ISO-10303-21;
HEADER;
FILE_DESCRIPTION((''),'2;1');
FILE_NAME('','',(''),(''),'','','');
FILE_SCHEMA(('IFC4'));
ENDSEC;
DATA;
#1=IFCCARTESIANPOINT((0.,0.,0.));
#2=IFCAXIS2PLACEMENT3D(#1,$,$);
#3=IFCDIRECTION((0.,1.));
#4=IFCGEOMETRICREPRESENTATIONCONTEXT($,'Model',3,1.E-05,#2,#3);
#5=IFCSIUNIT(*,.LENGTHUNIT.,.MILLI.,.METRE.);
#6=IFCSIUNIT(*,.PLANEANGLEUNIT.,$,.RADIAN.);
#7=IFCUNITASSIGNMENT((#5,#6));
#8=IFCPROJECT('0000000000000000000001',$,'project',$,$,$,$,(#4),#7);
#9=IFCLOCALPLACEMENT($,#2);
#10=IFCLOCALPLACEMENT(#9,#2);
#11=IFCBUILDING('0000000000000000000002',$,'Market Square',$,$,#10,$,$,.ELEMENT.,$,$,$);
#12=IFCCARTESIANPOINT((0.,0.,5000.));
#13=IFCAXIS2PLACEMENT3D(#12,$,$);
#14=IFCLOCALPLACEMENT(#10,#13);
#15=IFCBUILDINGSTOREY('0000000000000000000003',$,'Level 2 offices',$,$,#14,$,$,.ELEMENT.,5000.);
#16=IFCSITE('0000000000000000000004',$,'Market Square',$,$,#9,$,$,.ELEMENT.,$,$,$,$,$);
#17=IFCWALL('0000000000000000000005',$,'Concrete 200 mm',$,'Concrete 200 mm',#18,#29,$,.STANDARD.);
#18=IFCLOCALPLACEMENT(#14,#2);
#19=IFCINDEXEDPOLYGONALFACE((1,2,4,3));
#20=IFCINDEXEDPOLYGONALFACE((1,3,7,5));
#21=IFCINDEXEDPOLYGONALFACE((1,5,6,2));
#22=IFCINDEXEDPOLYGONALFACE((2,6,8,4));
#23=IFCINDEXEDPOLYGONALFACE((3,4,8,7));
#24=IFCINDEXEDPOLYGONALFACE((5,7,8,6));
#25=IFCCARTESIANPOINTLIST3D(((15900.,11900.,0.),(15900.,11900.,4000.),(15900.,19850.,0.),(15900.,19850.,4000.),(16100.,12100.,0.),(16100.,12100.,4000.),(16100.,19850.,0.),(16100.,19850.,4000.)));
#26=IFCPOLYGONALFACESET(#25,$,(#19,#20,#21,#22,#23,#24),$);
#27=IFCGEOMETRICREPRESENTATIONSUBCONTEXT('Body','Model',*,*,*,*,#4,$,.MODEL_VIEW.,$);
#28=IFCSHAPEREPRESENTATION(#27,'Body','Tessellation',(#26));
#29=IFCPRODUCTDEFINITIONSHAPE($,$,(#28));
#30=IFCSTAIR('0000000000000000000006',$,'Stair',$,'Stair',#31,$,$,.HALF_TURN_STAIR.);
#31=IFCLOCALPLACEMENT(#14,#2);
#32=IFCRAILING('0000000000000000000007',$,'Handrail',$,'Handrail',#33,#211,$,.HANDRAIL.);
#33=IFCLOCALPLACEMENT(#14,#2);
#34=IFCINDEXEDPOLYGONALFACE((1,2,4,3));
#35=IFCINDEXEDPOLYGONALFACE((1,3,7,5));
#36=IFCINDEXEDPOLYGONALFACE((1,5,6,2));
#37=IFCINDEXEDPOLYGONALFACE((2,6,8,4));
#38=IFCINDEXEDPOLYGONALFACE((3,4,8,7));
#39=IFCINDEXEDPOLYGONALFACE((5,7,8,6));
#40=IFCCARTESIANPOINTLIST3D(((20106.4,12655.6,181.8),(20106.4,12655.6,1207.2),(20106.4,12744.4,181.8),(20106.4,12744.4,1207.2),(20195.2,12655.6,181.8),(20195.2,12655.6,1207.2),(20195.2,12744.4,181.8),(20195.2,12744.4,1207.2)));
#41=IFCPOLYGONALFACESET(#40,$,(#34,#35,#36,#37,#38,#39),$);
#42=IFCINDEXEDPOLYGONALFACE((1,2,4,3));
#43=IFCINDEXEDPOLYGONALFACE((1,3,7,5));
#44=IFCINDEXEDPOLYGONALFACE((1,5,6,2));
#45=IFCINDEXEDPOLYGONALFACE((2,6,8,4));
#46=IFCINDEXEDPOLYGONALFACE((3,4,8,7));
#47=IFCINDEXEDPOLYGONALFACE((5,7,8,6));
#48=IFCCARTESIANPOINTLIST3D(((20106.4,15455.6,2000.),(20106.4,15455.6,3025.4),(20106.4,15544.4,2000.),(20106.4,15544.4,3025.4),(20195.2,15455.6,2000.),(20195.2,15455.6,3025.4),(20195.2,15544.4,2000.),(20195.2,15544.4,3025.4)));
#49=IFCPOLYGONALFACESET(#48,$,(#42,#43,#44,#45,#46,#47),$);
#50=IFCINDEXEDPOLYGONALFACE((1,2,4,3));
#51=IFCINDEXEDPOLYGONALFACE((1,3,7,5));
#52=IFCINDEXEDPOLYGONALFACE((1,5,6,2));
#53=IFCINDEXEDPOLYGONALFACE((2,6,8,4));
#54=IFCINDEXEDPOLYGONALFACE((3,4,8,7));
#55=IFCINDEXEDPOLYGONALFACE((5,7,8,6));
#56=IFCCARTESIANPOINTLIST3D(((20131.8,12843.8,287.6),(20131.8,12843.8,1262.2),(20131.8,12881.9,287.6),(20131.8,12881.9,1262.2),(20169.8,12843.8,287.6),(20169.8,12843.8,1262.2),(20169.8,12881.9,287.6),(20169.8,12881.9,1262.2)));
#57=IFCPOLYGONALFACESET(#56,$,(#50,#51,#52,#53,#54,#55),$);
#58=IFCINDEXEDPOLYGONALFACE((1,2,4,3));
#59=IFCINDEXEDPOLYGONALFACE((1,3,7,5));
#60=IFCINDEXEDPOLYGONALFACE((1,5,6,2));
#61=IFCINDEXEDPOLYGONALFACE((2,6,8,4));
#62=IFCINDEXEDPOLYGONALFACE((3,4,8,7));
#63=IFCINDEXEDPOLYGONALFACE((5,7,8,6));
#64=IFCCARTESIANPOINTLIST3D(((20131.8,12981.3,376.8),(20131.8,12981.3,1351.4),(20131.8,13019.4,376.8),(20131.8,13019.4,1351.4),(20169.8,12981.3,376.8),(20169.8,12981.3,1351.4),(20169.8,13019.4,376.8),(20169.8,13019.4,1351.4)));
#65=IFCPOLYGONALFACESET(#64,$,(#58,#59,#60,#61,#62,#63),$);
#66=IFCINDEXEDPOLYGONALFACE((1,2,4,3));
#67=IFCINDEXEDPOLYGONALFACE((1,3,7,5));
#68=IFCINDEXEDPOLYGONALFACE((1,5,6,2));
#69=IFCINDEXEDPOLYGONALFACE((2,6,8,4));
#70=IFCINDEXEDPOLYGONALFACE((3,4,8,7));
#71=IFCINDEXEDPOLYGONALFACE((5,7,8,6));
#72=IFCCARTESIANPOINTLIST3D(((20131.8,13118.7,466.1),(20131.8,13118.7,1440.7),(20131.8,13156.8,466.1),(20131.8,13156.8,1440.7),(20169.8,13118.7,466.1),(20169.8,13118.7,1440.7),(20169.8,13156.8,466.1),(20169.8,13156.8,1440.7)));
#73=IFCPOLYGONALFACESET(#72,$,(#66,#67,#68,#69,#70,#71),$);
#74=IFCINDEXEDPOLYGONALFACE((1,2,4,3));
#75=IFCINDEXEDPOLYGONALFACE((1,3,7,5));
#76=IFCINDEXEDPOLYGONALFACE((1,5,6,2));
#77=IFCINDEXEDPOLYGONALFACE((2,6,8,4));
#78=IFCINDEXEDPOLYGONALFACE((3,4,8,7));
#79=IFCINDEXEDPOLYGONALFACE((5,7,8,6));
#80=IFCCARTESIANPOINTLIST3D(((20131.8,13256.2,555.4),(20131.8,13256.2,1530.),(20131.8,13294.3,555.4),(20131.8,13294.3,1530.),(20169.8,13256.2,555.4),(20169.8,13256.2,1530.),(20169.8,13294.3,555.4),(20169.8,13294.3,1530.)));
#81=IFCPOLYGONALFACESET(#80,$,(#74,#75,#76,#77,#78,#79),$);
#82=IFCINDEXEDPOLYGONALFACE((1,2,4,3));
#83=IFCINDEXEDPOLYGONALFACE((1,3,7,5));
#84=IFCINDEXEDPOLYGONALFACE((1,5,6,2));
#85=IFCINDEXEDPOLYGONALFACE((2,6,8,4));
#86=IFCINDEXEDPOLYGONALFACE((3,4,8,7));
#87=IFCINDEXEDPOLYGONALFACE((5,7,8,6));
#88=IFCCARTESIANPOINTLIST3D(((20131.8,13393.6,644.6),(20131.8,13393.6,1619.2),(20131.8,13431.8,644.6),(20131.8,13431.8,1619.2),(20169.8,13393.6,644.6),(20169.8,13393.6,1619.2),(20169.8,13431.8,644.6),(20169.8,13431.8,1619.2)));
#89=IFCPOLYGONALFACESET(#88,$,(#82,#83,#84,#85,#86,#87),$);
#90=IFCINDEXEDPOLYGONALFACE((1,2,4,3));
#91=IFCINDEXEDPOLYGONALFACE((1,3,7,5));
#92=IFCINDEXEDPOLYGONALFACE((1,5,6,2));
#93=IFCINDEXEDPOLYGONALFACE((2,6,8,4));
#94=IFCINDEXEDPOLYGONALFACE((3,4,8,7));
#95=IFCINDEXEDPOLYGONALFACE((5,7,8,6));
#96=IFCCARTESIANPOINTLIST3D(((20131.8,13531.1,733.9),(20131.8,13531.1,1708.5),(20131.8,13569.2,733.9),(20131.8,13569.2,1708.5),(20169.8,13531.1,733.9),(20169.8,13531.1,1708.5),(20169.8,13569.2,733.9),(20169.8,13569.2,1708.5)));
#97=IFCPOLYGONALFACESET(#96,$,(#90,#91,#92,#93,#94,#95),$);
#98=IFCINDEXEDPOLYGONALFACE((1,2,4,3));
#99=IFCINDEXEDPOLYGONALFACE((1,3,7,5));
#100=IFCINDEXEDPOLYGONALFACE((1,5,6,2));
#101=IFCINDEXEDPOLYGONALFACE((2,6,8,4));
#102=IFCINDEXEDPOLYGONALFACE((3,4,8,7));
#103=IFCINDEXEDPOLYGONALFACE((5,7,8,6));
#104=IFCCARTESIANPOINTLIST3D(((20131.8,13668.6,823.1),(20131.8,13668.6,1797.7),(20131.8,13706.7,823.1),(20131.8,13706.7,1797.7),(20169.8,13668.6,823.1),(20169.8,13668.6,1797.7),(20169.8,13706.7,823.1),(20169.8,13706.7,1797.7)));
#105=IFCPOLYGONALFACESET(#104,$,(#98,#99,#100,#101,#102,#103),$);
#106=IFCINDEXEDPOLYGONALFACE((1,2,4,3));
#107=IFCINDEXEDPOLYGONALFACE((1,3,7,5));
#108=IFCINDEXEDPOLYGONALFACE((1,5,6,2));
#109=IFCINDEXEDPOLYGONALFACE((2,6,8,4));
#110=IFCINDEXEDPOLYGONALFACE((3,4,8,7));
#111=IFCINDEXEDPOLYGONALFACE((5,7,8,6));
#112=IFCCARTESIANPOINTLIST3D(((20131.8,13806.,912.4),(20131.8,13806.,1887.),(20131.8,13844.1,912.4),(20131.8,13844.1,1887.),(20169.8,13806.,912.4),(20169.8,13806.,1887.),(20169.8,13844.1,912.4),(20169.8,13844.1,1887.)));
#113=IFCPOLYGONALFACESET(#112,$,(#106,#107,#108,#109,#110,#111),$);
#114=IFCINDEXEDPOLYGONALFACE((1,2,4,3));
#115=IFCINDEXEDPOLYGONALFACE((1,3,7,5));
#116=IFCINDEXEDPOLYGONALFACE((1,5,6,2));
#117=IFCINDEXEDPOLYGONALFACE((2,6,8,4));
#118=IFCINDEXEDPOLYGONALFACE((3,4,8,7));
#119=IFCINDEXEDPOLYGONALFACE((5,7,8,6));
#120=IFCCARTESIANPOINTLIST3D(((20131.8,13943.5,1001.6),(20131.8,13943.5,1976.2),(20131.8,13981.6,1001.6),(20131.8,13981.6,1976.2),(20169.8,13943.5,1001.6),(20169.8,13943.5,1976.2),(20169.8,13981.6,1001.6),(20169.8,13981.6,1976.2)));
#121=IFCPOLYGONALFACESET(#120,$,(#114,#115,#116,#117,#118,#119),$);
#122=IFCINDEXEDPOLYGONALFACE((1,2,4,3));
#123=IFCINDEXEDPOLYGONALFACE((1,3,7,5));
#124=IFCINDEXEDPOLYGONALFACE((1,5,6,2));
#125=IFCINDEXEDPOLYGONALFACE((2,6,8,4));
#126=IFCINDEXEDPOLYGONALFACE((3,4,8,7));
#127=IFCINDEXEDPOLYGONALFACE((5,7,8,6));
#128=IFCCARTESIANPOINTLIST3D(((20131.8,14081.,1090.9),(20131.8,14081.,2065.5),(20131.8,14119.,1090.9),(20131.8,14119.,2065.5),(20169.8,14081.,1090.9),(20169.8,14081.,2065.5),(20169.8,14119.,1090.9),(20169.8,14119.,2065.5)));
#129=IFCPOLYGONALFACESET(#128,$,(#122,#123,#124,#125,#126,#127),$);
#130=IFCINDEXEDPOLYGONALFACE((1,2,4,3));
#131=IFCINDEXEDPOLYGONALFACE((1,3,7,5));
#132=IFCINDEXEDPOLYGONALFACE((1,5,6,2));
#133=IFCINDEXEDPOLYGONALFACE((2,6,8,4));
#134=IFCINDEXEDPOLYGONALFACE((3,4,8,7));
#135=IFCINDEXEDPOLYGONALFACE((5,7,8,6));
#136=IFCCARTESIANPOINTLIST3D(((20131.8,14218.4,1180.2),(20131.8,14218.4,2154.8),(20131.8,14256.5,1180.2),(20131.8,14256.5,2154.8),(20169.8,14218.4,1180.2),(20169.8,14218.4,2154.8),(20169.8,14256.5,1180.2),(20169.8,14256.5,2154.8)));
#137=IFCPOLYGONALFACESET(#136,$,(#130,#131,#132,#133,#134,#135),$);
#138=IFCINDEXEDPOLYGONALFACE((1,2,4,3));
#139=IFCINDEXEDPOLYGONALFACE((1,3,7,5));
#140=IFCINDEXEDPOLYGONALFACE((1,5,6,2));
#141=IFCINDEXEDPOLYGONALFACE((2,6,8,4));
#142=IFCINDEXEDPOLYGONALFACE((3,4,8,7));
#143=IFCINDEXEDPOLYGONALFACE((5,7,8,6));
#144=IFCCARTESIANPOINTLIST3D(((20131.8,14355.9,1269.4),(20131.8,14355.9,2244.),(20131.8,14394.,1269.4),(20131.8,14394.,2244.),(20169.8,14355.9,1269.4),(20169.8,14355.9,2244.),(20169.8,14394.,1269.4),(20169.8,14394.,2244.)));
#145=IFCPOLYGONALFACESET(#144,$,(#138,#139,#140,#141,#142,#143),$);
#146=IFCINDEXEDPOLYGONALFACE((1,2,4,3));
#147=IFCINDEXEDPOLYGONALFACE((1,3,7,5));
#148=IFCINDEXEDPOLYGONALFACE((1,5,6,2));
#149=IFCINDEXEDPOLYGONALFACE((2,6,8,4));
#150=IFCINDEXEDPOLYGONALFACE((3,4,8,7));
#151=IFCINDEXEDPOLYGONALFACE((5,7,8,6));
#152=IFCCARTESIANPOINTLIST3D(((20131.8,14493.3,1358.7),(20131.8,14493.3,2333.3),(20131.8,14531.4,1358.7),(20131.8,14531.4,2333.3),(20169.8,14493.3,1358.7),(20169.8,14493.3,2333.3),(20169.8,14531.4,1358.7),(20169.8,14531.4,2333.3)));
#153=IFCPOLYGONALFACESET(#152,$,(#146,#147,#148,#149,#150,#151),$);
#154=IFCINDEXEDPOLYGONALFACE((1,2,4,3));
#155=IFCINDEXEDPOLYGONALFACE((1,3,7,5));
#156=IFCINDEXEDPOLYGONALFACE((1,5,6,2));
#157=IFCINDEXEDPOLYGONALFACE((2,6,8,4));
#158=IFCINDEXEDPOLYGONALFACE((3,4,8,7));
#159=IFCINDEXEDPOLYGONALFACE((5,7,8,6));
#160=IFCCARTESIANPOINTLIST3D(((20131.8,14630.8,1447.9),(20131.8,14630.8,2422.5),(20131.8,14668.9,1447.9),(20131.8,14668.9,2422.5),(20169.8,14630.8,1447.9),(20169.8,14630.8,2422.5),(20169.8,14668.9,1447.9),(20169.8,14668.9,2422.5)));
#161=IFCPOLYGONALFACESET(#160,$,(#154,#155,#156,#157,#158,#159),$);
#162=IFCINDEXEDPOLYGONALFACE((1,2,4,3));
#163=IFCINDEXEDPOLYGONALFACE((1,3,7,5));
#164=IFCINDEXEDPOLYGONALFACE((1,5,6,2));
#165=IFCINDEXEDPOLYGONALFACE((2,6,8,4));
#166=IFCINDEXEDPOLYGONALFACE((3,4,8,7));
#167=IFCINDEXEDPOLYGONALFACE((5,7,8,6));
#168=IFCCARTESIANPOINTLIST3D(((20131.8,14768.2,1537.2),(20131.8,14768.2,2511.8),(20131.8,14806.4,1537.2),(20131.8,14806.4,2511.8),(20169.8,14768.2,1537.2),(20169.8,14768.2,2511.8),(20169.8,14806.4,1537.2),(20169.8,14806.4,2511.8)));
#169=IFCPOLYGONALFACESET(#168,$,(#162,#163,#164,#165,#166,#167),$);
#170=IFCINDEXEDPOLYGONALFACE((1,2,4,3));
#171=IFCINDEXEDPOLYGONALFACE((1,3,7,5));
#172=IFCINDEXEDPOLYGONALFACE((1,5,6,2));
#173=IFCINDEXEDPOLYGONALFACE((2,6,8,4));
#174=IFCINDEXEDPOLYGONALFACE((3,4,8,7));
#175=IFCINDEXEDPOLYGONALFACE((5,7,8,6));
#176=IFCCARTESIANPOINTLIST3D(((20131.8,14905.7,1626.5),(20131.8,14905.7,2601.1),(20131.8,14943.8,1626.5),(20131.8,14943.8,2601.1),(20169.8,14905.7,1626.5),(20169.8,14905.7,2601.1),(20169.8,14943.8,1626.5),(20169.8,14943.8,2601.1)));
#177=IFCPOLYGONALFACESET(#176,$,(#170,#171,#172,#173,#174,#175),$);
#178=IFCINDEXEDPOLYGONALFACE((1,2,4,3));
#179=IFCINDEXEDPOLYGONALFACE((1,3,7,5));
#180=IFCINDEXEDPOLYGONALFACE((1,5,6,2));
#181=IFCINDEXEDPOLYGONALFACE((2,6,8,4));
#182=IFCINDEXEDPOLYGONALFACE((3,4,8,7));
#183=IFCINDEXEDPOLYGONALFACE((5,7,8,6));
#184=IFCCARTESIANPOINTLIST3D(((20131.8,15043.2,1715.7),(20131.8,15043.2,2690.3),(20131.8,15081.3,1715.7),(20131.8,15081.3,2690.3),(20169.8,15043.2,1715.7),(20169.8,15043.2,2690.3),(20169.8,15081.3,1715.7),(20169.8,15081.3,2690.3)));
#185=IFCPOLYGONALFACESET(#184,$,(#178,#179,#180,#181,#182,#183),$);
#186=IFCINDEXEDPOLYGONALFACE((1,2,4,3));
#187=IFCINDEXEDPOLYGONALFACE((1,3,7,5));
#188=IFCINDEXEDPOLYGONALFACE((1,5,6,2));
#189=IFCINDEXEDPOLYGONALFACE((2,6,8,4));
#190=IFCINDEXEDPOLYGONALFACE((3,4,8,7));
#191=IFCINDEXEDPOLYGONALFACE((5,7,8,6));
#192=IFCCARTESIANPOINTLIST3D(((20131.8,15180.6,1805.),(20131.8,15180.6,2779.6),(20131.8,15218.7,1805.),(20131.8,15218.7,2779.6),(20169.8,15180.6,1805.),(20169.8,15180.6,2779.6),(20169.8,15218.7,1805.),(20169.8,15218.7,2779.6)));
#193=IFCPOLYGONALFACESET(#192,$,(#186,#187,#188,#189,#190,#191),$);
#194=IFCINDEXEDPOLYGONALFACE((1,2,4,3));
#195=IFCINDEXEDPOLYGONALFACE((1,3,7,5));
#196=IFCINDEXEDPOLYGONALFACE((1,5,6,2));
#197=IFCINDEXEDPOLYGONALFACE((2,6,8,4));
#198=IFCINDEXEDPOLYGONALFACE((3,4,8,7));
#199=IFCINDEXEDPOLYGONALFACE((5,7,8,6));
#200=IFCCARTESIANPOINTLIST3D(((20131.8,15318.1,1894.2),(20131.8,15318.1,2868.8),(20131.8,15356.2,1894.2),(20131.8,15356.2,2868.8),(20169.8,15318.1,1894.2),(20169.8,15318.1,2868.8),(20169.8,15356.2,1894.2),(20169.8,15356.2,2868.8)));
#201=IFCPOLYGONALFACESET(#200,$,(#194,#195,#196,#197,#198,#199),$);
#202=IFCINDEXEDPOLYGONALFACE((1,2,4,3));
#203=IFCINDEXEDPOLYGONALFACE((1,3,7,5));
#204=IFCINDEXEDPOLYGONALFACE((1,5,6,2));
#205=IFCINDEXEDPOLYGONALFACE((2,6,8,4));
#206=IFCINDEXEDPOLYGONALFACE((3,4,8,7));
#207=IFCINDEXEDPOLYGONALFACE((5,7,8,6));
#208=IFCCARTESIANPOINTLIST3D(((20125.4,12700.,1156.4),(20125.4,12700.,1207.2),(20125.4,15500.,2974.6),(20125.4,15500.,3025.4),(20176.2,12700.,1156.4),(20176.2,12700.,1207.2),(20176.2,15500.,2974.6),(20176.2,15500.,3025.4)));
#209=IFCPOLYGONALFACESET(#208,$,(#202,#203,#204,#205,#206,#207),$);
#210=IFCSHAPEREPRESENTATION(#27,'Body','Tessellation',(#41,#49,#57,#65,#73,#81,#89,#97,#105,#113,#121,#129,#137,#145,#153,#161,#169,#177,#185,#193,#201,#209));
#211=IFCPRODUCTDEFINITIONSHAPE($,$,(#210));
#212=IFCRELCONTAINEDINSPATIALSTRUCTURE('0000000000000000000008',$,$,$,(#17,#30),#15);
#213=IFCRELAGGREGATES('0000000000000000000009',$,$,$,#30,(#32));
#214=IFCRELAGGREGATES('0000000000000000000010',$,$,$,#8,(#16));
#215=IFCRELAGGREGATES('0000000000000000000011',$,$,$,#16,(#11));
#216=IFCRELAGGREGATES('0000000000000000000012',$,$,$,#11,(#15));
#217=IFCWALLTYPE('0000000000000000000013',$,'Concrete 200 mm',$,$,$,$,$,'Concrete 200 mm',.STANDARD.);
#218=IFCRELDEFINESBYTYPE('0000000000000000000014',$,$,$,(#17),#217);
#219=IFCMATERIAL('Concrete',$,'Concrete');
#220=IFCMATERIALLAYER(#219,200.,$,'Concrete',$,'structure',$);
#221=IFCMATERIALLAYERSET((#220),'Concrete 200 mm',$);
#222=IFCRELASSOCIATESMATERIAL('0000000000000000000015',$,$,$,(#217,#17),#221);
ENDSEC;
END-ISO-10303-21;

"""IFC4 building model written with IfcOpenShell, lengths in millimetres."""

from ifc_helpers import new_model, si_unit, direction, frame, origin, origin_with_axes, place, context, subcontext, project, spatial, polyline, outline, extrude, material, layer, layer_set, layer_usage, type_object, element, aggregate, save


model = new_model("IFC4")

# Units and contexts
model_context = context("Model", 3, precision=1e-05, world=origin(), true_north=direction((0.0, 1.0)))
body_context = subcontext(model_context, "Body", "Model", "MODEL_VIEW")
ifc_project = project(units=[si_unit("LENGTHUNIT", "METRE", prefix="MILLI"), si_unit("PLANEANGLEUNIT", "RADIAN")], contexts=[model_context])

# Site, building, storey
site_placement = place(None, origin())
site = spatial("IfcSite", under=ifc_project, at=site_placement, Name="Market Square", CompositionType="ELEMENT")
building_placement = place(site_placement, origin())
building = spatial("IfcBuilding", under=site, at=building_placement, Name="Market Square", CompositionType="ELEMENT")
storey_placement = place(building_placement, frame((0.0, 0.0, 5000.0)))
storey = spatial("IfcBuildingStorey", under=building, at=storey_placement, Name="Level 2 offices", CompositionType="ELEMENT", Elevation=5000.0)

# Wall
ifc_material = material(Name="Concrete", Category="Concrete")
ifc_layer = layer(ifc_material, 200.0, Name="Concrete", Category="structure")
ifc_layer_set = layer_set([ifc_layer], Name="Concrete 200 mm")
ifc_layer_usage = layer_usage(ifc_layer_set, "AXIS2", "NEGATIVE", 100.0)
wall_type = type_object("IfcWallType", Name="Concrete 200 mm", ElementType="Concrete 200 mm", PredefinedType="STANDARD", material=ifc_layer_set)
wall_placement = place(storey_placement, frame((16000.0, 12000.0, 0.0), z_axis=(0.0, 0.0, 1.0), x_axis=(0.0, 1.0, 0.0)))
element("IfcWall", 1, at=wall_placement, inside=storey, type_object=wall_type, material=ifc_layer_usage, Name="Concrete 200 mm", ObjectType="Concrete 200 mm", PredefinedType="STANDARD", context=body_context, shape_type="SweptSolid", body=[
    extrude(outline(polyline([(100.0, -100.0), (7850.0, -100.0), (7850.0, 100.0), (-100.0, 100.0), (100.0, -100.0)])), origin(), (0.0, 0.0, 1.0), 4000.0),
])

# Stair, railing
stair_placement = place(storey_placement, origin_with_axes())
stair = element("IfcStair", 2, at=stair_placement, inside=storey, Name="Stair", ObjectType="Stair", PredefinedType="HALF_TURN_STAIR")
railing_1_placement = place(storey_placement, origin_with_axes())
railing_1 = element("IfcRailing", 3, at=railing_1_placement, Name="Handrail", ObjectType="Handrail", PredefinedType="HANDRAIL", context=body_context, shape_type="SweptSolid", body=[
    extrude(outline(polyline([(-44.5, -44.5), (44.5, -44.5), (44.5, 44.5), (-44.5, 44.5), (-44.5, -44.5)])), frame((20150.8, 12700.0, 181.8), z_axis=(0.0, 0.0, 1.0), x_axis=(1.0, 0.0, 0.0)), (0.0, 0.0, 1.0), 1025.4),
    extrude(outline(polyline([(-44.5, -44.5), (44.5, -44.5), (44.5, 44.5), (-44.5, 44.5), (-44.5, -44.5)])), frame((20150.8, 15500.0, 2000.0), z_axis=(0.0, 0.0, 1.0), x_axis=(1.0, 0.0, 0.0)), (0.0, 0.0, 1.0), 1025.4),
    extrude(outline(polyline([(-19.1, -19.1), (19.1, -19.1), (19.1, 19.1), (-19.1, 19.1), (-19.1, -19.1)])), frame((20150.8, 12862.9, 287.6), z_axis=(0.0, 0.0, 1.0), x_axis=(1.0, 0.0, 0.0)), (0.0, 0.0, 1.0), 974.6),
    extrude(outline(polyline([(-19.1, -19.1), (19.1, -19.1), (19.1, 19.1), (-19.1, 19.1), (-19.1, -19.1)])), frame((20150.8, 13000.3, 376.8), z_axis=(0.0, 0.0, 1.0), x_axis=(1.0, 0.0, 0.0)), (0.0, 0.0, 1.0), 974.6),
    extrude(outline(polyline([(-19.1, -19.1), (19.1, -19.1), (19.1, 19.1), (-19.1, 19.1), (-19.1, -19.1)])), frame((20150.8, 13137.8, 466.1), z_axis=(0.0, 0.0, 1.0), x_axis=(1.0, 0.0, 0.0)), (0.0, 0.0, 1.0), 974.6),
    extrude(outline(polyline([(-19.1, -19.1), (19.1, -19.1), (19.1, 19.1), (-19.1, 19.1), (-19.1, -19.1)])), frame((20150.8, 13275.2, 555.4), z_axis=(0.0, 0.0, 1.0), x_axis=(1.0, 0.0, 0.0)), (0.0, 0.0, 1.0), 974.6),
    extrude(outline(polyline([(-19.1, -19.1), (19.1, -19.1), (19.1, 19.1), (-19.1, 19.1), (-19.1, -19.1)])), frame((20150.8, 13412.7, 644.6), z_axis=(0.0, 0.0, 1.0), x_axis=(1.0, 0.0, 0.0)), (0.0, 0.0, 1.0), 974.6),
    extrude(outline(polyline([(-19.1, -19.1), (19.1, -19.1), (19.1, 19.1), (-19.1, 19.1), (-19.1, -19.1)])), frame((20150.8, 13550.2, 733.9), z_axis=(0.0, 0.0, 1.0), x_axis=(1.0, 0.0, 0.0)), (0.0, 0.0, 1.0), 974.6),
    extrude(outline(polyline([(-19.1, -19.1), (19.1, -19.1), (19.1, 19.1), (-19.1, 19.1), (-19.1, -19.1)])), frame((20150.8, 13687.6, 823.1), z_axis=(0.0, 0.0, 1.0), x_axis=(1.0, 0.0, 0.0)), (0.0, 0.0, 1.0), 974.6),
    extrude(outline(polyline([(-19.1, -19.1), (19.1, -19.1), (19.1, 19.1), (-19.1, 19.1), (-19.1, -19.1)])), frame((20150.8, 13825.1, 912.4), z_axis=(0.0, 0.0, 1.0), x_axis=(1.0, 0.0, 0.0)), (0.0, 0.0, 1.0), 974.6),
    extrude(outline(polyline([(-19.1, -19.1), (19.1, -19.1), (19.1, 19.1), (-19.1, 19.1), (-19.1, -19.1)])), frame((20150.8, 13962.5, 1001.6), z_axis=(0.0, 0.0, 1.0), x_axis=(1.0, 0.0, 0.0)), (0.0, 0.0, 1.0), 974.6),
    extrude(outline(polyline([(-19.1, -19.1), (19.1, -19.1), (19.1, 19.1), (-19.1, 19.1), (-19.1, -19.1)])), frame((20150.8, 14100.0, 1090.9), z_axis=(0.0, 0.0, 1.0), x_axis=(1.0, 0.0, 0.0)), (0.0, 0.0, 1.0), 974.6),
    extrude(outline(polyline([(-19.1, -19.1), (19.1, -19.1), (19.1, 19.1), (-19.1, 19.1), (-19.1, -19.1)])), frame((20150.8, 14237.5, 1180.2), z_axis=(0.0, 0.0, 1.0), x_axis=(1.0, 0.0, 0.0)), (0.0, 0.0, 1.0), 974.6),
    extrude(outline(polyline([(-19.1, -19.1), (19.1, -19.1), (19.1, 19.1), (-19.1, 19.1), (-19.1, -19.1)])), frame((20150.8, 14374.9, 1269.4), z_axis=(0.0, 0.0, 1.0), x_axis=(1.0, 0.0, 0.0)), (0.0, 0.0, 1.0), 974.6),
    extrude(outline(polyline([(-19.1, -19.1), (19.1, -19.1), (19.1, 19.1), (-19.1, 19.1), (-19.1, -19.1)])), frame((20150.8, 14512.4, 1358.7), z_axis=(0.0, 0.0, 1.0), x_axis=(1.0, 0.0, 0.0)), (0.0, 0.0, 1.0), 974.6),
    extrude(outline(polyline([(-19.1, -19.1), (19.1, -19.1), (19.1, 19.1), (-19.1, 19.1), (-19.1, -19.1)])), frame((20150.8, 14649.8, 1447.9), z_axis=(0.0, 0.0, 1.0), x_axis=(1.0, 0.0, 0.0)), (0.0, 0.0, 1.0), 974.6),
    extrude(outline(polyline([(-19.1, -19.1), (19.1, -19.1), (19.1, 19.1), (-19.1, 19.1), (-19.1, -19.1)])), frame((20150.8, 14787.3, 1537.2), z_axis=(0.0, 0.0, 1.0), x_axis=(1.0, 0.0, 0.0)), (0.0, 0.0, 1.0), 974.6),
    extrude(outline(polyline([(-19.1, -19.1), (19.1, -19.1), (19.1, 19.1), (-19.1, 19.1), (-19.1, -19.1)])), frame((20150.8, 14924.8, 1626.5), z_axis=(0.0, 0.0, 1.0), x_axis=(1.0, 0.0, 0.0)), (0.0, 0.0, 1.0), 974.6),
    extrude(outline(polyline([(-19.1, -19.1), (19.1, -19.1), (19.1, 19.1), (-19.1, 19.1), (-19.1, -19.1)])), frame((20150.8, 15062.2, 1715.7), z_axis=(0.0, 0.0, 1.0), x_axis=(1.0, 0.0, 0.0)), (0.0, 0.0, 1.0), 974.6),
    extrude(outline(polyline([(-19.1, -19.1), (19.1, -19.1), (19.1, 19.1), (-19.1, 19.1), (-19.1, -19.1)])), frame((20150.8, 15199.7, 1805.0), z_axis=(0.0, 0.0, 1.0), x_axis=(1.0, 0.0, 0.0)), (0.0, 0.0, 1.0), 974.6),
    extrude(outline(polyline([(-19.1, -19.1), (19.1, -19.1), (19.1, 19.1), (-19.1, 19.1), (-19.1, -19.1)])), frame((20150.8, 15337.1, 1894.2), z_axis=(0.0, 0.0, 1.0), x_axis=(1.0, 0.0, 0.0)), (0.0, 0.0, 1.0), 974.6),
    extrude(outline(polyline([(0.0, 0.0), (50.8, 0.0), (50.8, 50.8), (0.0, 50.8), (0.0, 0.0)])), frame((20176.2, 12700.0, 1156.4), z_axis=(0.0, 1.0, 0.0), x_axis=(-1.0, 0.0, 0.0)), (0.0, 0.544605, 0.838692), 3338.5),
])
aggregate(stair, [railing_1])

save(model, "model.ifc")
